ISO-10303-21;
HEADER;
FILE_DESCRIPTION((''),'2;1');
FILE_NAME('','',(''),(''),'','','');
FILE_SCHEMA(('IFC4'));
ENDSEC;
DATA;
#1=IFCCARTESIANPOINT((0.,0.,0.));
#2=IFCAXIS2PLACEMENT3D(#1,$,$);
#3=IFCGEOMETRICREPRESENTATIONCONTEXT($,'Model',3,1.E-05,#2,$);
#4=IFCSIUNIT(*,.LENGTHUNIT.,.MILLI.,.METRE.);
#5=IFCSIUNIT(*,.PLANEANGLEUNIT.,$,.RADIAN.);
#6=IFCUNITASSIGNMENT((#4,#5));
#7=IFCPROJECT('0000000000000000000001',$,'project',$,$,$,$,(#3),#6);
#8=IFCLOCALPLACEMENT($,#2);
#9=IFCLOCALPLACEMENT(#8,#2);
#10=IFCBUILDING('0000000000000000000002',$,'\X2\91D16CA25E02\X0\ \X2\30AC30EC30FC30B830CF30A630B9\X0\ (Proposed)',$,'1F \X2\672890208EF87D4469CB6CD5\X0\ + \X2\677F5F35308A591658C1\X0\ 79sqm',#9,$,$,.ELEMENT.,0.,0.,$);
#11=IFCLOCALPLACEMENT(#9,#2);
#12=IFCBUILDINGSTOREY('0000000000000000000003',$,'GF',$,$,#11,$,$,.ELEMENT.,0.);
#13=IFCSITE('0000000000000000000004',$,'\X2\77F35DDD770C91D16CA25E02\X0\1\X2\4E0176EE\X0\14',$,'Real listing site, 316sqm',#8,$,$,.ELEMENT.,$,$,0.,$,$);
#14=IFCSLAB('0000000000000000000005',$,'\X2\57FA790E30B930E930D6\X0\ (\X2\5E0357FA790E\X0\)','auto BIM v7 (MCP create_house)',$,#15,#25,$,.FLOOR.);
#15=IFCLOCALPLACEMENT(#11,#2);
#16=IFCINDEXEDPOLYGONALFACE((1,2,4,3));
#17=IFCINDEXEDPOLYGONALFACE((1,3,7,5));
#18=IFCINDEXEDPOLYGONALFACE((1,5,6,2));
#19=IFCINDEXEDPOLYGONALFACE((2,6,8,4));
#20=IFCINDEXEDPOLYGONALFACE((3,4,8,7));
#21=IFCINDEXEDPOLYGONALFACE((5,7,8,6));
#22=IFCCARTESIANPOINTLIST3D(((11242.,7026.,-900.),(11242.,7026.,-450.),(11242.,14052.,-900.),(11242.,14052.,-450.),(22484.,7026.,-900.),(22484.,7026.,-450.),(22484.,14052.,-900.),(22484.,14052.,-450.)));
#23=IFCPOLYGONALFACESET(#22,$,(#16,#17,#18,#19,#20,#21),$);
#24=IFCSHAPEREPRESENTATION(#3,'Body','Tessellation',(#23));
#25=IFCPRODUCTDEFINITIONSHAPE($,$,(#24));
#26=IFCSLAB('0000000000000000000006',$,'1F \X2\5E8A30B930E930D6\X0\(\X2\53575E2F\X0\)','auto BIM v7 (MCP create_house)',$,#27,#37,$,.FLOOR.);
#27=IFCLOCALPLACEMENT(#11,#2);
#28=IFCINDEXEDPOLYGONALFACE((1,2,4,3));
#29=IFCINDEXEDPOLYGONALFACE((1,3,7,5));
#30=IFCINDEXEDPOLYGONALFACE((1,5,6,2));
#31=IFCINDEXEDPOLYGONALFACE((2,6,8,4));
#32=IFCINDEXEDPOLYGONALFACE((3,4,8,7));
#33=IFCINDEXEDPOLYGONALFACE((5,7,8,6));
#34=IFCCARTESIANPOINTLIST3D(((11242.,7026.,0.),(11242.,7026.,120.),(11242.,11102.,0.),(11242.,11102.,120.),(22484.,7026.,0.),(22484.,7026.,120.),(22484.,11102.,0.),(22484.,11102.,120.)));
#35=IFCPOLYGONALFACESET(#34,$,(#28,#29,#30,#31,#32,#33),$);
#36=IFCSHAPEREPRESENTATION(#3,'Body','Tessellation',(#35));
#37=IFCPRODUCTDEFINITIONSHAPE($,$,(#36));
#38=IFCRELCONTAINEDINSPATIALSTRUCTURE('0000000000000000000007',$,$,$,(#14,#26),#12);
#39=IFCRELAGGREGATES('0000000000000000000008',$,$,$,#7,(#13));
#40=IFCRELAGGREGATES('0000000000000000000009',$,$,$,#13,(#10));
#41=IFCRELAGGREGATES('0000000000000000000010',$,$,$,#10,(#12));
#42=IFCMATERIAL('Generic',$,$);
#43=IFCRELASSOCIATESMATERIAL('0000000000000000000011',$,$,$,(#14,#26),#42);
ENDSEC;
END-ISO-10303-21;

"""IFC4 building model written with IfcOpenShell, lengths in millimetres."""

from ifc_helpers import new_model, si_unit, frame, frame_2d, origin, place, context, project, spatial, rectangle, extrude, material, element, save


model = new_model("IFC4")

# Units and contexts
model_context = context("Model", 3, precision=1e-05, world=origin())
ifc_project = project(units=[si_unit("LENGTHUNIT", "METRE", prefix="MILLI"), si_unit("PLANEANGLEUNIT", "RADIAN")], contexts=[model_context])

# Site, building, storey
site_placement = place(None, origin())
site = spatial("IfcSite", under=ifc_project, at=site_placement, Name="石川県金沢市1丁目14", ObjectType="Real listing site, 316sqm", CompositionType="ELEMENT", RefElevation=0.0)
building_placement = place(site_placement, origin())
building = spatial("IfcBuilding", under=site, at=building_placement, Name="金沢市 ガレージハウス (Proposed)", ObjectType="1F 木造軸組構法 + 板張り外壁 79sqm", CompositionType="ELEMENT", ElevationOfRefHeight=0.0, ElevationOfTerrain=0.0)
storey_placement = place(building_placement, origin())
storey = spatial("IfcBuildingStorey", under=building, at=storey_placement, Name="GF", CompositionType="ELEMENT", Elevation=0.0)

# Slabs
ifc_material = material(Name="Generic")
slab_1_placement = place(storey_placement, frame((5621.0, 3513.0, -450.0)))
element("IfcSlab", 1, at=slab_1_placement, inside=storey, material=ifc_material, Name="基礎スラブ (布基礎)", Description="auto BIM v7 (MCP create_house)", PredefinedType="FLOOR", context=model_context, shape_type="SweptSolid", body=[
    extrude(rectangle(XDim=11242.0, YDim=7026.0, at=frame_2d((5621.0, 3513.0))), frame((5621.0, 3513.0, -450.0)), (0.0, 0.0, 1.0), 450.0),
])
slab_2_placement = place(storey_placement, frame((5621.0, 3513.0, 0.0)))
element("IfcSlab", 2, at=slab_2_placement, inside=storey, material=ifc_material, Name="1F 床スラブ(南帯)", Description="auto BIM v7 (MCP create_house)", PredefinedType="FLOOR", context=model_context, shape_type="SweptSolid", body=[
    extrude(rectangle(XDim=11242.0, YDim=4076.0, at=frame_2d((5621.0, 2038.0))), frame((5621.0, 3513.0, 0.0)), (0.0, 0.0, 1.0), 120.0),
])

save(model, "model.ifc")
